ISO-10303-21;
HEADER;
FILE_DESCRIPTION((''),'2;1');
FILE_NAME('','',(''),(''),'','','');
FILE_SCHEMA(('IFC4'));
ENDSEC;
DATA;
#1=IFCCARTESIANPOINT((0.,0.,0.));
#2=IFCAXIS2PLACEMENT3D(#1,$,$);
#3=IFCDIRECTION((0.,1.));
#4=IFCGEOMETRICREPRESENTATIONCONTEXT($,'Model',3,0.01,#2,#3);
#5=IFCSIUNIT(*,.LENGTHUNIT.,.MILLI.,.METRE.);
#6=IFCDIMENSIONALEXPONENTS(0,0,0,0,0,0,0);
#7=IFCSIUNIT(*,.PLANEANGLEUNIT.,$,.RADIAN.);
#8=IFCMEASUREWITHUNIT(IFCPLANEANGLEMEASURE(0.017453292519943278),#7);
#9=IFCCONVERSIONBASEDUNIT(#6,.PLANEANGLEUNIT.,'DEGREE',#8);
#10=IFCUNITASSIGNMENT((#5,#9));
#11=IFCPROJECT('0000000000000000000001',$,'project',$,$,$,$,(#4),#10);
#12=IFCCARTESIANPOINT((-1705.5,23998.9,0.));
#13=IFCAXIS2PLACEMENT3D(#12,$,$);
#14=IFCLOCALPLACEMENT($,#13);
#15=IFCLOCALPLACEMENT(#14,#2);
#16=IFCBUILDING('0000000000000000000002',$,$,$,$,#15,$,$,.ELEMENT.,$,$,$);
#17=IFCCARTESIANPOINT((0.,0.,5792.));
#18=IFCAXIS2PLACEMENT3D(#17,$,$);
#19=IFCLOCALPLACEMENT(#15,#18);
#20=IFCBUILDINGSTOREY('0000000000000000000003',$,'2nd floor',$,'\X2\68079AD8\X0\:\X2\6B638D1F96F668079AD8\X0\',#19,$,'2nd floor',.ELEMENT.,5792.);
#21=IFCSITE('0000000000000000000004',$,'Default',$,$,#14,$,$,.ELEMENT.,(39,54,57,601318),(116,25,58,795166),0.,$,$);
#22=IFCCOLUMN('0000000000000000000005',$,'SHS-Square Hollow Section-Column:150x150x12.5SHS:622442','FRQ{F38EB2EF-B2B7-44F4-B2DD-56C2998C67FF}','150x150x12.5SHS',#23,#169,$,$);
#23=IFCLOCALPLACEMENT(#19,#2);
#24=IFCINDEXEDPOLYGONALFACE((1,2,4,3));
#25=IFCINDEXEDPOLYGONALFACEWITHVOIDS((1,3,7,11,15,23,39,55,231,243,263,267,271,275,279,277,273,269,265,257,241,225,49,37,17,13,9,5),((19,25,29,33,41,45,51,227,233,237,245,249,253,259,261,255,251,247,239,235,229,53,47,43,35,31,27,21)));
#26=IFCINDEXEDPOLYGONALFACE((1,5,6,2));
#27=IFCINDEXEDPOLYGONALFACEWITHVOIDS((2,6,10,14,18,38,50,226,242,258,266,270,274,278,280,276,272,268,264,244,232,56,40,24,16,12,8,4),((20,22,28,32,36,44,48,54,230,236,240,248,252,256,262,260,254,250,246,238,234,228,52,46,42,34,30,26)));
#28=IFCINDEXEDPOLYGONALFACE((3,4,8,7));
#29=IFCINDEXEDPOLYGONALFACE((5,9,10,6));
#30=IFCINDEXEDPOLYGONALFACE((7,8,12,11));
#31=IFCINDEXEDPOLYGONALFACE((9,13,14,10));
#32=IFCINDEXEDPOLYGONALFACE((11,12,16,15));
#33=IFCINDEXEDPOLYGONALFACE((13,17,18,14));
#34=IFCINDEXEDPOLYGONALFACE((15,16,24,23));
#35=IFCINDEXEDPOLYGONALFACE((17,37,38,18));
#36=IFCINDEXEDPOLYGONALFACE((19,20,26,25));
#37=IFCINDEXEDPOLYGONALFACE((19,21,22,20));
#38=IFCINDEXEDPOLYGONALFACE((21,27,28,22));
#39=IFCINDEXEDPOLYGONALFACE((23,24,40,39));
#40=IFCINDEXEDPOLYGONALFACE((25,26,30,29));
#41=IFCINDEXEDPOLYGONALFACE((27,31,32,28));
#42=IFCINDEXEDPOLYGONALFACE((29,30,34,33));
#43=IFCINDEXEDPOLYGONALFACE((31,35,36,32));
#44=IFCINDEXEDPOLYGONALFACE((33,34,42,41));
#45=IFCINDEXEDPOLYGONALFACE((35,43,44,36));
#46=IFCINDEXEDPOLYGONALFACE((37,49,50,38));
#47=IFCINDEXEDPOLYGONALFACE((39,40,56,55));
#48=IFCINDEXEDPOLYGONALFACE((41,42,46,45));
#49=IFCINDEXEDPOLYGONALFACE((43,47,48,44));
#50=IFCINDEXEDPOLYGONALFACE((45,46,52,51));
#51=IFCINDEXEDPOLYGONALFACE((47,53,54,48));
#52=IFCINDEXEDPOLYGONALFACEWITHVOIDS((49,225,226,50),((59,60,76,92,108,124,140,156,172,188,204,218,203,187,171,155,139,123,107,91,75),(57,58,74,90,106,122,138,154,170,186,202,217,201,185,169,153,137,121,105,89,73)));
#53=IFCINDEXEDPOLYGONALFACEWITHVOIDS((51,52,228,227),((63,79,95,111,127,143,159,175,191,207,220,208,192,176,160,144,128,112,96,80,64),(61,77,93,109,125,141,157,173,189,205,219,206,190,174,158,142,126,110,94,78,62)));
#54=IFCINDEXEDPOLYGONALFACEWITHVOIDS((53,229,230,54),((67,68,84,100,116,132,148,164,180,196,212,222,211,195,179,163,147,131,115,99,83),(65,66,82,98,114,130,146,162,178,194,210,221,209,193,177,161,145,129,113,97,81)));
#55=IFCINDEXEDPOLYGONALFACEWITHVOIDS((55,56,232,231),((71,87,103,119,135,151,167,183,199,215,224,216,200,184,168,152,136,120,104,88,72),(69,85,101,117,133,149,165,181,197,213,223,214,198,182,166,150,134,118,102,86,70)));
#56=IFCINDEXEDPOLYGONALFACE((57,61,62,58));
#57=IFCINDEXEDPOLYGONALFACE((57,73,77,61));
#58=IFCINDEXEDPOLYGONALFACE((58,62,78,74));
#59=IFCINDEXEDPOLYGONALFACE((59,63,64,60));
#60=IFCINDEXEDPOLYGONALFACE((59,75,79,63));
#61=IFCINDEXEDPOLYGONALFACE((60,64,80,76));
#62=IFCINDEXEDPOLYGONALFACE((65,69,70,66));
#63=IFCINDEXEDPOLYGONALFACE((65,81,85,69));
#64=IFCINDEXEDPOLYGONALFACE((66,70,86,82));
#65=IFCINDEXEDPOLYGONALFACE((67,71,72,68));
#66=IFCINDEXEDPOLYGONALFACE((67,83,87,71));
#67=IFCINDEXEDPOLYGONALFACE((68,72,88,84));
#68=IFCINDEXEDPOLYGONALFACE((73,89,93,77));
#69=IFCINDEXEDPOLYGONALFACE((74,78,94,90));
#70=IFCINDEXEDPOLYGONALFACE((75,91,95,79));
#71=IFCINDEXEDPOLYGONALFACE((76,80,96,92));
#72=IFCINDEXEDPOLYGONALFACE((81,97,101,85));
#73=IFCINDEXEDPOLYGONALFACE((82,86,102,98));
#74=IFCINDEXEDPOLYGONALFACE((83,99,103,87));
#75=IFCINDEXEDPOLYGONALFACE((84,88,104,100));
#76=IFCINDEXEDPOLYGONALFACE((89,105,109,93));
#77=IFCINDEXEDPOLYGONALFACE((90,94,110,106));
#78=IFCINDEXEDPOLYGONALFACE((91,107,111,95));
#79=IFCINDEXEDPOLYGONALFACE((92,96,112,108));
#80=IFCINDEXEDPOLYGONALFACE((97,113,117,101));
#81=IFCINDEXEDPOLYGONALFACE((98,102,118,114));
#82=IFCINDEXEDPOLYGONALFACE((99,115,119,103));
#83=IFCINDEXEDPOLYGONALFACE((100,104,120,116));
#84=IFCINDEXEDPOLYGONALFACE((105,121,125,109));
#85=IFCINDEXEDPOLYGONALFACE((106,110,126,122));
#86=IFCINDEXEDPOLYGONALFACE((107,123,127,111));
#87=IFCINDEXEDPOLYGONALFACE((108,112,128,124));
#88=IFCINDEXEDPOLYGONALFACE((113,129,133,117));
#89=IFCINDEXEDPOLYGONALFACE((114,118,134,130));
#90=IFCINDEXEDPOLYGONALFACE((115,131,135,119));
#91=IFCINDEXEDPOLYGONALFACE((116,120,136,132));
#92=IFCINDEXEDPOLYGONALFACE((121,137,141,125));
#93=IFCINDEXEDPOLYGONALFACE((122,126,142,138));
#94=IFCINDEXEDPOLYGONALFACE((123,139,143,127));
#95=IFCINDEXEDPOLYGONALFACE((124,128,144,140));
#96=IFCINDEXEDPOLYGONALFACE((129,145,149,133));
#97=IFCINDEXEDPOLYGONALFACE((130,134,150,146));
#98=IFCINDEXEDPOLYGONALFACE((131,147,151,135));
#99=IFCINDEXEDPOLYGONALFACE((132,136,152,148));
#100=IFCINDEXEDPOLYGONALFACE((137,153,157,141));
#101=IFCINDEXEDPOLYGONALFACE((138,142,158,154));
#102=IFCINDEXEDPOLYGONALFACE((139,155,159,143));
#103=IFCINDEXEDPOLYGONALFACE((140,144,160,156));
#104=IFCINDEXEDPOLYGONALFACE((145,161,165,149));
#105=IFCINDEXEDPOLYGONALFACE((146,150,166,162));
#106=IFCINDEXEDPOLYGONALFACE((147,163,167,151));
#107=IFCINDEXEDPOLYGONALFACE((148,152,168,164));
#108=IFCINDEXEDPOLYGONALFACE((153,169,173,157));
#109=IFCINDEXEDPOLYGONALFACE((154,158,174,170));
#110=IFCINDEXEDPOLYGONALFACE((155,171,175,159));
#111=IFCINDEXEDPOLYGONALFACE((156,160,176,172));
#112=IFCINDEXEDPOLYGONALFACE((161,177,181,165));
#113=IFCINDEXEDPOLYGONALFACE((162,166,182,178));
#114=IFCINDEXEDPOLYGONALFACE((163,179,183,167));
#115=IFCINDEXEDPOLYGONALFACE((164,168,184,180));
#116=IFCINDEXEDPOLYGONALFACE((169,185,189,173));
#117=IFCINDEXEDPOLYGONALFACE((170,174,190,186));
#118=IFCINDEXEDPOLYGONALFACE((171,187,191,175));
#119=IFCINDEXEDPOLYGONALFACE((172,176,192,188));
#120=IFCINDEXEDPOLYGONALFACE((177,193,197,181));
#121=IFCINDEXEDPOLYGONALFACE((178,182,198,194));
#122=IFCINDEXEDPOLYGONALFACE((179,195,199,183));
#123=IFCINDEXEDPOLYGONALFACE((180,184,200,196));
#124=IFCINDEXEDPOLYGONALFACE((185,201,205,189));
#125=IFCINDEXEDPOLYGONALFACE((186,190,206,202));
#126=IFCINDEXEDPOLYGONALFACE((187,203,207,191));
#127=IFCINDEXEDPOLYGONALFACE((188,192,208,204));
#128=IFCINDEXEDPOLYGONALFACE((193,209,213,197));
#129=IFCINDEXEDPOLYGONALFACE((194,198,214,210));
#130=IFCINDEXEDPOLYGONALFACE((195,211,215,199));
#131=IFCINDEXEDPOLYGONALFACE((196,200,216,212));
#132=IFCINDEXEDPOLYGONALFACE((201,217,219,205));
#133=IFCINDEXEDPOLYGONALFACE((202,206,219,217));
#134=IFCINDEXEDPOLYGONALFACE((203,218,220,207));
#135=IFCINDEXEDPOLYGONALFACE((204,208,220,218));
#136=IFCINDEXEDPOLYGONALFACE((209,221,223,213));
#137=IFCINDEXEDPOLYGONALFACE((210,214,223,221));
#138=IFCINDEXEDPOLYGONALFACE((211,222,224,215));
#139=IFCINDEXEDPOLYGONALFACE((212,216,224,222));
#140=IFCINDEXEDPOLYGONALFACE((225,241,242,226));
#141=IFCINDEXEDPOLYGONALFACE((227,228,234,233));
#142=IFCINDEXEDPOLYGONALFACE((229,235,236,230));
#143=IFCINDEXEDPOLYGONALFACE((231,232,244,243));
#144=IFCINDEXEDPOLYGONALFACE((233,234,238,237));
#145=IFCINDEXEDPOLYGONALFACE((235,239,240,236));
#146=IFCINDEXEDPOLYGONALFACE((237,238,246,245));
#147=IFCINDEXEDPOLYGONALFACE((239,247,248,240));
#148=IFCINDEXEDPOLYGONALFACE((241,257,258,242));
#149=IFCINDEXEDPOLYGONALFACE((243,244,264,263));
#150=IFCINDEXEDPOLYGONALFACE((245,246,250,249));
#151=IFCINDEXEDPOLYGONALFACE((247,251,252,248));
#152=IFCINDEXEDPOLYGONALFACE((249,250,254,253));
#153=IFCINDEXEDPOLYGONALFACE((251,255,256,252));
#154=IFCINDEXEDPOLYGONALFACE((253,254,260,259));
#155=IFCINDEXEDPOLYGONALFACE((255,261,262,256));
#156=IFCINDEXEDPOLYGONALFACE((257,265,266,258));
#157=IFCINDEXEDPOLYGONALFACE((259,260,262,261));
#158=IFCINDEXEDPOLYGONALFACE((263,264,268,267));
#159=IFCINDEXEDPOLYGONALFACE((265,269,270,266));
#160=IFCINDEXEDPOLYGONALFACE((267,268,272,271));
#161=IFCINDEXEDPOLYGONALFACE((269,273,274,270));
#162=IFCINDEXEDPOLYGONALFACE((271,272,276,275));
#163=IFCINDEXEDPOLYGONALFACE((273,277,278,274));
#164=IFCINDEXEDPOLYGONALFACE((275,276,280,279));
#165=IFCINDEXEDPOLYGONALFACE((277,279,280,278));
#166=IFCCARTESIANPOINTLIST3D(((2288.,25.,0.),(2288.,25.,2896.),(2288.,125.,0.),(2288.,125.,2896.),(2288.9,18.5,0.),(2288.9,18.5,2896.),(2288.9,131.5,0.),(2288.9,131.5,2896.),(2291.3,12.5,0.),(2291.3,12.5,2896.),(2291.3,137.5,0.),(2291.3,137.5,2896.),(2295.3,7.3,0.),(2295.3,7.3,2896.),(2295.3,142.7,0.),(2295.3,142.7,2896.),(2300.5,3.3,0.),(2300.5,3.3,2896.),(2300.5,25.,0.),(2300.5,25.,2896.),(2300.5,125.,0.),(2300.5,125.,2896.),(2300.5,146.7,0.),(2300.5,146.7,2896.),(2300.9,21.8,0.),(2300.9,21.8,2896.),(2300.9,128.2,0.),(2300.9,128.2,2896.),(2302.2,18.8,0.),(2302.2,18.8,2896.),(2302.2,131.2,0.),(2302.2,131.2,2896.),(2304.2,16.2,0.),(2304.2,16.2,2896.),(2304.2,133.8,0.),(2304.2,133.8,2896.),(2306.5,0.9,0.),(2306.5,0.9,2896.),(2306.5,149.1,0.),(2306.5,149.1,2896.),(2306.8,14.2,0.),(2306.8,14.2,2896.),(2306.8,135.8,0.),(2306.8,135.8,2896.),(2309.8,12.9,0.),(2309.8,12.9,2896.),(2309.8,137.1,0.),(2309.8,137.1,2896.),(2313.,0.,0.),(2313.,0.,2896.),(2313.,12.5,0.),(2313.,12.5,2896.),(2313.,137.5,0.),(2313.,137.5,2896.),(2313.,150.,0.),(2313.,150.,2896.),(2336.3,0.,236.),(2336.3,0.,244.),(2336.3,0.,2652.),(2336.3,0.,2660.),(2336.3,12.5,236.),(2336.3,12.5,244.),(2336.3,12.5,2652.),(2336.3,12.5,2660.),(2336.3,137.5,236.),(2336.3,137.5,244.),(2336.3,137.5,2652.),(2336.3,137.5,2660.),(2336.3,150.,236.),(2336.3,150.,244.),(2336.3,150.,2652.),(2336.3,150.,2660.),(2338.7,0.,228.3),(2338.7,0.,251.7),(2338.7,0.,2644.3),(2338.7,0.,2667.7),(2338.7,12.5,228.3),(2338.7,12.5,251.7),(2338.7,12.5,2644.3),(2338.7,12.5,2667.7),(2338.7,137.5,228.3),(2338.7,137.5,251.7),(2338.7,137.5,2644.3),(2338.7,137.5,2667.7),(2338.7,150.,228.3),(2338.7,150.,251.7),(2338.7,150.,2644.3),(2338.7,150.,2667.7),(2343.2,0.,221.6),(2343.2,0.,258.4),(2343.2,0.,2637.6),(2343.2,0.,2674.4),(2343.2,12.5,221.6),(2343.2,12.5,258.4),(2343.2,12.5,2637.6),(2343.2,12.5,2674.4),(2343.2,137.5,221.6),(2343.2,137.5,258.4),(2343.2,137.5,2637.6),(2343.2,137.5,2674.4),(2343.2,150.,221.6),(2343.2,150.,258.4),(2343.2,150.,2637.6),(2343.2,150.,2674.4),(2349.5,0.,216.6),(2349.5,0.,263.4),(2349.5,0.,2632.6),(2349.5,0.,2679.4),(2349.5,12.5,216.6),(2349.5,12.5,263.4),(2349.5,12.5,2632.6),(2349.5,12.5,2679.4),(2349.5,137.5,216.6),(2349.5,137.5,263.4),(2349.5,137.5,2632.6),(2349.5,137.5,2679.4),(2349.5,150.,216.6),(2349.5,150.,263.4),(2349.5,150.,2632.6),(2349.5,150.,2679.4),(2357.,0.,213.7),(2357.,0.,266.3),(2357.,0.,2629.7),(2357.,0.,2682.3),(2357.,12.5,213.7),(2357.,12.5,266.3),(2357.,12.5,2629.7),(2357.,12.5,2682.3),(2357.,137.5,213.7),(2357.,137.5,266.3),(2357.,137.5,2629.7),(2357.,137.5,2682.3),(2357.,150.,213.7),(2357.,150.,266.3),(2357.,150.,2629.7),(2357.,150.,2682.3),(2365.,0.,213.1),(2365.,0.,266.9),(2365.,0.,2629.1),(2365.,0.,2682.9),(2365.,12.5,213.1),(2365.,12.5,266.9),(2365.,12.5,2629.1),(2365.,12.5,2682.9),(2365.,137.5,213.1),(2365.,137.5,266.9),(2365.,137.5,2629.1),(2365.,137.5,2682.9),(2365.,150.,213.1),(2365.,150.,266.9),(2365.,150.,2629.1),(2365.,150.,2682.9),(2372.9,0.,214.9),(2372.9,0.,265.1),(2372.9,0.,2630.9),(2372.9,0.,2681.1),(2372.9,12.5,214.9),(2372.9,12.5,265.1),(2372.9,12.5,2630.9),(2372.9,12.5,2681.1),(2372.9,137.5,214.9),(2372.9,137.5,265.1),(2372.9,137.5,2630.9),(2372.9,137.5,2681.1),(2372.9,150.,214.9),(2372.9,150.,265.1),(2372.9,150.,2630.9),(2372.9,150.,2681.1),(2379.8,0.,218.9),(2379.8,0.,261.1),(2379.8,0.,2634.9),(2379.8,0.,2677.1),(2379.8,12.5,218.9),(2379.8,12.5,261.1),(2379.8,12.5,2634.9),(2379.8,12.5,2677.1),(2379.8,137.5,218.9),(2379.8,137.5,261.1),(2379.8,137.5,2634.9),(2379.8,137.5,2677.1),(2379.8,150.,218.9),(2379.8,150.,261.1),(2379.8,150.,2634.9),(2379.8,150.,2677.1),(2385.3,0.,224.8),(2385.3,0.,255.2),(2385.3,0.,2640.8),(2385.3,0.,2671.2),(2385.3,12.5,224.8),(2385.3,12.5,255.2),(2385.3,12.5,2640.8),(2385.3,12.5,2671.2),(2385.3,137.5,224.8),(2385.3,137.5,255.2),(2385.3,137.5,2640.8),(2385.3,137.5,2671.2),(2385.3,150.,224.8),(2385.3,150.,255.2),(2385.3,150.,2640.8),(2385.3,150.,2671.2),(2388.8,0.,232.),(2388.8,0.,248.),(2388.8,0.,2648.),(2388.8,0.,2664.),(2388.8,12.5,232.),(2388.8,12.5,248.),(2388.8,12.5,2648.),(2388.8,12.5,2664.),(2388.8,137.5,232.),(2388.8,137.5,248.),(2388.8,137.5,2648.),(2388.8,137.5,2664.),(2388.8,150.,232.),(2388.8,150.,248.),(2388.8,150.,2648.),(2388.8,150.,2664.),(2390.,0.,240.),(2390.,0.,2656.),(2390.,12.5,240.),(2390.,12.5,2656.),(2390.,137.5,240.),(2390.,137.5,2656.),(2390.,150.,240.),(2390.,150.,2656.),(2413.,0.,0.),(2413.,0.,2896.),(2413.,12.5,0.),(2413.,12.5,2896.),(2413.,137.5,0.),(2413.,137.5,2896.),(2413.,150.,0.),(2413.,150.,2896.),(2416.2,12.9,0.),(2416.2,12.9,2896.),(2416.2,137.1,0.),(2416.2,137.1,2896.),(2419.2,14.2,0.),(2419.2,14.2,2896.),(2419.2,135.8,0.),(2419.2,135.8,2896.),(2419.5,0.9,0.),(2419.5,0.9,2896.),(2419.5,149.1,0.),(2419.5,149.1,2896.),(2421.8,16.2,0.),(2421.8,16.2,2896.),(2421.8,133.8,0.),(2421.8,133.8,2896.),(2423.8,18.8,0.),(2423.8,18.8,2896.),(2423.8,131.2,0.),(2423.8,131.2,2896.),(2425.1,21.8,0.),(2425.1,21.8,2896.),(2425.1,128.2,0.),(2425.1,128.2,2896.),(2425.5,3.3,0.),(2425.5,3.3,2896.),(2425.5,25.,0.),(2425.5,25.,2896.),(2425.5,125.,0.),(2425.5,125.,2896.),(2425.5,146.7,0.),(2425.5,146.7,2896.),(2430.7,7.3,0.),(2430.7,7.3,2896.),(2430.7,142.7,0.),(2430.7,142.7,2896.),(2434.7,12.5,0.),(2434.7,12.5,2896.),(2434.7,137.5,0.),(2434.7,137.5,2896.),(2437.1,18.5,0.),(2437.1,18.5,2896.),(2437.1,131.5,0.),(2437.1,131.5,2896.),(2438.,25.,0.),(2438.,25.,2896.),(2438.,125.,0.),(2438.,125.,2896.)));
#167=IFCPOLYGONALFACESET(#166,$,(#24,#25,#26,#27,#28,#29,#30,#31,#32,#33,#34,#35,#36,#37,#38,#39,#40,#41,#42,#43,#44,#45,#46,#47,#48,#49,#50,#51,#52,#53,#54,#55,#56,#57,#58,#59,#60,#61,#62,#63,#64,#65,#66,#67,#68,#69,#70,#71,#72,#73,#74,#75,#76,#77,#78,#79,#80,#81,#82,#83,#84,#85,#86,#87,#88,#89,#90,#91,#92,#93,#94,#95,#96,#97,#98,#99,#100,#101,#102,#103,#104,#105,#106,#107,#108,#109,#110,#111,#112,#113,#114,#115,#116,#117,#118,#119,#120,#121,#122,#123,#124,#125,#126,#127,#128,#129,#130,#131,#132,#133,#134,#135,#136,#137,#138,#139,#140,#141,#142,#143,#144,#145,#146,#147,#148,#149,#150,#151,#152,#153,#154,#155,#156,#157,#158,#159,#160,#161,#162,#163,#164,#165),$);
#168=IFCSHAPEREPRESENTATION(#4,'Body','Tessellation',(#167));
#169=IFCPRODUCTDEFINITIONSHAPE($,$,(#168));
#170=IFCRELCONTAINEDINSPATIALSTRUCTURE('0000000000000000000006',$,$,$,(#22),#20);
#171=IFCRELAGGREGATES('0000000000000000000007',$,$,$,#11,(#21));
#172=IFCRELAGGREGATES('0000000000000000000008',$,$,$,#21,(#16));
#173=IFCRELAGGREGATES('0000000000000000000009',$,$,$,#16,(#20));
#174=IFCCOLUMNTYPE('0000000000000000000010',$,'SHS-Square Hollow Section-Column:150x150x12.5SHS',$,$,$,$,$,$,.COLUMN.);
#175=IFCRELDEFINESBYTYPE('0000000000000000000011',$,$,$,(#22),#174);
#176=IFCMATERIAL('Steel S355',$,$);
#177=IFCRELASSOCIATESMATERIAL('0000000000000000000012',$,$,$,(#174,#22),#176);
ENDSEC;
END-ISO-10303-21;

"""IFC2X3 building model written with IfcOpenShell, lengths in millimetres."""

from ifc_helpers import new_model, entity, si_unit, converted_unit, direction, frame, frame_2d, origin, origin_2d, place, context, project, spatial, circle_curve, hollow_rectangle, outline, extrude, material, type_object, element, save


model = new_model("IFC2X3")

# Units and contexts
model_context = context("Model", 3, precision=0.01, world=origin(), true_north=direction((0.0, 1.0)))
ifc_project = project(units=[si_unit("LENGTHUNIT", "METRE", prefix="MILLI"), converted_unit("PLANEANGLEUNIT", "DEGREE", entity("IfcPlaneAngleMeasure", 0.017453292519943278), si_unit("PLANEANGLEUNIT", "RADIAN"), dimensions=[0, 0, 0, 0, 0, 0, 0])], contexts=[model_context])

# Site, building, storey
site_placement = place(None, frame((-1705.5, 23998.9, 0.0)))
site = spatial("IfcSite", under=ifc_project, at=site_placement, Name="Default", CompositionType="ELEMENT", RefLatitude=(39, 54, 57, 601318), RefLongitude=(116, 25, 58, 795166), RefElevation=0.0)
building_placement = place(site_placement, origin())
building = spatial("IfcBuilding", under=site, at=building_placement, CompositionType="ELEMENT")
storey_placement = place(building_placement, frame((0.0, 0.0, 5792.0)))
storey = spatial("IfcBuildingStorey", under=building, at=storey_placement, Name="2nd floor", ObjectType="标高:正负零标高", LongName="2nd floor", CompositionType="ELEMENT", Elevation=5792.0)

# Shared definitions
ifc_material_1 = material(Name="Steel S355")

# Column, openings
column_type_1 = type_object("IfcColumnType", Name="SHS-Square Hollow Section-Column:150x150x12.5SHS", PredefinedType="COLUMN", material=ifc_material_1)
column_1_placement = place(storey_placement, frame((2363.0, 75.0, 2896.0), z_axis=(0.0, 0.0, 1.0), x_axis=(0.0, -1.0, 0.0)))
column_1 = element("IfcColumn", 1, at=column_1_placement, inside=storey, type_object=column_type_1, material=ifc_material_1, Name="SHS-Square Hollow Section-Column:150x150x12.5SHS:622442", Description="FRQ{F38EB2EF-B2B7-44F4-B2DD-56C2998C67FF}", ObjectType="150x150x12.5SHS", context=model_context, shape_type="SweptSolid", body=[
    extrude(hollow_rectangle(XDim=150.0, YDim=150.0, WallThickness=12.5, InnerFilletRadius=12.5, OuterFilletRadius=25.0, at=origin_2d()), origin(), (0.0, 0.0, -1.0), 2896.0),
])
opening_1_placement = place(column_1_placement, frame((-175.1, 0.0, 0.0), z_axis=(1.0, 0.0, 0.0), x_axis=(0.0, 1.0, 0.0)))
element("IfcOpeningElement", 2, at=opening_1_placement, cuts=column_1, ObjectType="Opening", context=model_context, shape_type="SweptSolid", body=[
    extrude(outline(circle_curve(frame_2d((0.0, -240.0), x_axis=(1.0, 0.0)), 27.0)), origin(), (0.0, 0.0, 1.0), 350.2),
])
opening_2_placement = place(column_1_placement, frame((-175.1, 0.0, -2896.0), z_axis=(1.0, 0.0, 0.0), x_axis=(0.0, 1.0, 0.0)))
element("IfcOpeningElement", 3, at=opening_2_placement, cuts=column_1, ObjectType="Opening", context=model_context, shape_type="SweptSolid", body=[
    extrude(outline(circle_curve(frame_2d((0.0, 240.0), x_axis=(1.0, 0.0)), 27.0)), origin(), (0.0, 0.0, 1.0), 350.2),
])

save(model, "model.ifc")
